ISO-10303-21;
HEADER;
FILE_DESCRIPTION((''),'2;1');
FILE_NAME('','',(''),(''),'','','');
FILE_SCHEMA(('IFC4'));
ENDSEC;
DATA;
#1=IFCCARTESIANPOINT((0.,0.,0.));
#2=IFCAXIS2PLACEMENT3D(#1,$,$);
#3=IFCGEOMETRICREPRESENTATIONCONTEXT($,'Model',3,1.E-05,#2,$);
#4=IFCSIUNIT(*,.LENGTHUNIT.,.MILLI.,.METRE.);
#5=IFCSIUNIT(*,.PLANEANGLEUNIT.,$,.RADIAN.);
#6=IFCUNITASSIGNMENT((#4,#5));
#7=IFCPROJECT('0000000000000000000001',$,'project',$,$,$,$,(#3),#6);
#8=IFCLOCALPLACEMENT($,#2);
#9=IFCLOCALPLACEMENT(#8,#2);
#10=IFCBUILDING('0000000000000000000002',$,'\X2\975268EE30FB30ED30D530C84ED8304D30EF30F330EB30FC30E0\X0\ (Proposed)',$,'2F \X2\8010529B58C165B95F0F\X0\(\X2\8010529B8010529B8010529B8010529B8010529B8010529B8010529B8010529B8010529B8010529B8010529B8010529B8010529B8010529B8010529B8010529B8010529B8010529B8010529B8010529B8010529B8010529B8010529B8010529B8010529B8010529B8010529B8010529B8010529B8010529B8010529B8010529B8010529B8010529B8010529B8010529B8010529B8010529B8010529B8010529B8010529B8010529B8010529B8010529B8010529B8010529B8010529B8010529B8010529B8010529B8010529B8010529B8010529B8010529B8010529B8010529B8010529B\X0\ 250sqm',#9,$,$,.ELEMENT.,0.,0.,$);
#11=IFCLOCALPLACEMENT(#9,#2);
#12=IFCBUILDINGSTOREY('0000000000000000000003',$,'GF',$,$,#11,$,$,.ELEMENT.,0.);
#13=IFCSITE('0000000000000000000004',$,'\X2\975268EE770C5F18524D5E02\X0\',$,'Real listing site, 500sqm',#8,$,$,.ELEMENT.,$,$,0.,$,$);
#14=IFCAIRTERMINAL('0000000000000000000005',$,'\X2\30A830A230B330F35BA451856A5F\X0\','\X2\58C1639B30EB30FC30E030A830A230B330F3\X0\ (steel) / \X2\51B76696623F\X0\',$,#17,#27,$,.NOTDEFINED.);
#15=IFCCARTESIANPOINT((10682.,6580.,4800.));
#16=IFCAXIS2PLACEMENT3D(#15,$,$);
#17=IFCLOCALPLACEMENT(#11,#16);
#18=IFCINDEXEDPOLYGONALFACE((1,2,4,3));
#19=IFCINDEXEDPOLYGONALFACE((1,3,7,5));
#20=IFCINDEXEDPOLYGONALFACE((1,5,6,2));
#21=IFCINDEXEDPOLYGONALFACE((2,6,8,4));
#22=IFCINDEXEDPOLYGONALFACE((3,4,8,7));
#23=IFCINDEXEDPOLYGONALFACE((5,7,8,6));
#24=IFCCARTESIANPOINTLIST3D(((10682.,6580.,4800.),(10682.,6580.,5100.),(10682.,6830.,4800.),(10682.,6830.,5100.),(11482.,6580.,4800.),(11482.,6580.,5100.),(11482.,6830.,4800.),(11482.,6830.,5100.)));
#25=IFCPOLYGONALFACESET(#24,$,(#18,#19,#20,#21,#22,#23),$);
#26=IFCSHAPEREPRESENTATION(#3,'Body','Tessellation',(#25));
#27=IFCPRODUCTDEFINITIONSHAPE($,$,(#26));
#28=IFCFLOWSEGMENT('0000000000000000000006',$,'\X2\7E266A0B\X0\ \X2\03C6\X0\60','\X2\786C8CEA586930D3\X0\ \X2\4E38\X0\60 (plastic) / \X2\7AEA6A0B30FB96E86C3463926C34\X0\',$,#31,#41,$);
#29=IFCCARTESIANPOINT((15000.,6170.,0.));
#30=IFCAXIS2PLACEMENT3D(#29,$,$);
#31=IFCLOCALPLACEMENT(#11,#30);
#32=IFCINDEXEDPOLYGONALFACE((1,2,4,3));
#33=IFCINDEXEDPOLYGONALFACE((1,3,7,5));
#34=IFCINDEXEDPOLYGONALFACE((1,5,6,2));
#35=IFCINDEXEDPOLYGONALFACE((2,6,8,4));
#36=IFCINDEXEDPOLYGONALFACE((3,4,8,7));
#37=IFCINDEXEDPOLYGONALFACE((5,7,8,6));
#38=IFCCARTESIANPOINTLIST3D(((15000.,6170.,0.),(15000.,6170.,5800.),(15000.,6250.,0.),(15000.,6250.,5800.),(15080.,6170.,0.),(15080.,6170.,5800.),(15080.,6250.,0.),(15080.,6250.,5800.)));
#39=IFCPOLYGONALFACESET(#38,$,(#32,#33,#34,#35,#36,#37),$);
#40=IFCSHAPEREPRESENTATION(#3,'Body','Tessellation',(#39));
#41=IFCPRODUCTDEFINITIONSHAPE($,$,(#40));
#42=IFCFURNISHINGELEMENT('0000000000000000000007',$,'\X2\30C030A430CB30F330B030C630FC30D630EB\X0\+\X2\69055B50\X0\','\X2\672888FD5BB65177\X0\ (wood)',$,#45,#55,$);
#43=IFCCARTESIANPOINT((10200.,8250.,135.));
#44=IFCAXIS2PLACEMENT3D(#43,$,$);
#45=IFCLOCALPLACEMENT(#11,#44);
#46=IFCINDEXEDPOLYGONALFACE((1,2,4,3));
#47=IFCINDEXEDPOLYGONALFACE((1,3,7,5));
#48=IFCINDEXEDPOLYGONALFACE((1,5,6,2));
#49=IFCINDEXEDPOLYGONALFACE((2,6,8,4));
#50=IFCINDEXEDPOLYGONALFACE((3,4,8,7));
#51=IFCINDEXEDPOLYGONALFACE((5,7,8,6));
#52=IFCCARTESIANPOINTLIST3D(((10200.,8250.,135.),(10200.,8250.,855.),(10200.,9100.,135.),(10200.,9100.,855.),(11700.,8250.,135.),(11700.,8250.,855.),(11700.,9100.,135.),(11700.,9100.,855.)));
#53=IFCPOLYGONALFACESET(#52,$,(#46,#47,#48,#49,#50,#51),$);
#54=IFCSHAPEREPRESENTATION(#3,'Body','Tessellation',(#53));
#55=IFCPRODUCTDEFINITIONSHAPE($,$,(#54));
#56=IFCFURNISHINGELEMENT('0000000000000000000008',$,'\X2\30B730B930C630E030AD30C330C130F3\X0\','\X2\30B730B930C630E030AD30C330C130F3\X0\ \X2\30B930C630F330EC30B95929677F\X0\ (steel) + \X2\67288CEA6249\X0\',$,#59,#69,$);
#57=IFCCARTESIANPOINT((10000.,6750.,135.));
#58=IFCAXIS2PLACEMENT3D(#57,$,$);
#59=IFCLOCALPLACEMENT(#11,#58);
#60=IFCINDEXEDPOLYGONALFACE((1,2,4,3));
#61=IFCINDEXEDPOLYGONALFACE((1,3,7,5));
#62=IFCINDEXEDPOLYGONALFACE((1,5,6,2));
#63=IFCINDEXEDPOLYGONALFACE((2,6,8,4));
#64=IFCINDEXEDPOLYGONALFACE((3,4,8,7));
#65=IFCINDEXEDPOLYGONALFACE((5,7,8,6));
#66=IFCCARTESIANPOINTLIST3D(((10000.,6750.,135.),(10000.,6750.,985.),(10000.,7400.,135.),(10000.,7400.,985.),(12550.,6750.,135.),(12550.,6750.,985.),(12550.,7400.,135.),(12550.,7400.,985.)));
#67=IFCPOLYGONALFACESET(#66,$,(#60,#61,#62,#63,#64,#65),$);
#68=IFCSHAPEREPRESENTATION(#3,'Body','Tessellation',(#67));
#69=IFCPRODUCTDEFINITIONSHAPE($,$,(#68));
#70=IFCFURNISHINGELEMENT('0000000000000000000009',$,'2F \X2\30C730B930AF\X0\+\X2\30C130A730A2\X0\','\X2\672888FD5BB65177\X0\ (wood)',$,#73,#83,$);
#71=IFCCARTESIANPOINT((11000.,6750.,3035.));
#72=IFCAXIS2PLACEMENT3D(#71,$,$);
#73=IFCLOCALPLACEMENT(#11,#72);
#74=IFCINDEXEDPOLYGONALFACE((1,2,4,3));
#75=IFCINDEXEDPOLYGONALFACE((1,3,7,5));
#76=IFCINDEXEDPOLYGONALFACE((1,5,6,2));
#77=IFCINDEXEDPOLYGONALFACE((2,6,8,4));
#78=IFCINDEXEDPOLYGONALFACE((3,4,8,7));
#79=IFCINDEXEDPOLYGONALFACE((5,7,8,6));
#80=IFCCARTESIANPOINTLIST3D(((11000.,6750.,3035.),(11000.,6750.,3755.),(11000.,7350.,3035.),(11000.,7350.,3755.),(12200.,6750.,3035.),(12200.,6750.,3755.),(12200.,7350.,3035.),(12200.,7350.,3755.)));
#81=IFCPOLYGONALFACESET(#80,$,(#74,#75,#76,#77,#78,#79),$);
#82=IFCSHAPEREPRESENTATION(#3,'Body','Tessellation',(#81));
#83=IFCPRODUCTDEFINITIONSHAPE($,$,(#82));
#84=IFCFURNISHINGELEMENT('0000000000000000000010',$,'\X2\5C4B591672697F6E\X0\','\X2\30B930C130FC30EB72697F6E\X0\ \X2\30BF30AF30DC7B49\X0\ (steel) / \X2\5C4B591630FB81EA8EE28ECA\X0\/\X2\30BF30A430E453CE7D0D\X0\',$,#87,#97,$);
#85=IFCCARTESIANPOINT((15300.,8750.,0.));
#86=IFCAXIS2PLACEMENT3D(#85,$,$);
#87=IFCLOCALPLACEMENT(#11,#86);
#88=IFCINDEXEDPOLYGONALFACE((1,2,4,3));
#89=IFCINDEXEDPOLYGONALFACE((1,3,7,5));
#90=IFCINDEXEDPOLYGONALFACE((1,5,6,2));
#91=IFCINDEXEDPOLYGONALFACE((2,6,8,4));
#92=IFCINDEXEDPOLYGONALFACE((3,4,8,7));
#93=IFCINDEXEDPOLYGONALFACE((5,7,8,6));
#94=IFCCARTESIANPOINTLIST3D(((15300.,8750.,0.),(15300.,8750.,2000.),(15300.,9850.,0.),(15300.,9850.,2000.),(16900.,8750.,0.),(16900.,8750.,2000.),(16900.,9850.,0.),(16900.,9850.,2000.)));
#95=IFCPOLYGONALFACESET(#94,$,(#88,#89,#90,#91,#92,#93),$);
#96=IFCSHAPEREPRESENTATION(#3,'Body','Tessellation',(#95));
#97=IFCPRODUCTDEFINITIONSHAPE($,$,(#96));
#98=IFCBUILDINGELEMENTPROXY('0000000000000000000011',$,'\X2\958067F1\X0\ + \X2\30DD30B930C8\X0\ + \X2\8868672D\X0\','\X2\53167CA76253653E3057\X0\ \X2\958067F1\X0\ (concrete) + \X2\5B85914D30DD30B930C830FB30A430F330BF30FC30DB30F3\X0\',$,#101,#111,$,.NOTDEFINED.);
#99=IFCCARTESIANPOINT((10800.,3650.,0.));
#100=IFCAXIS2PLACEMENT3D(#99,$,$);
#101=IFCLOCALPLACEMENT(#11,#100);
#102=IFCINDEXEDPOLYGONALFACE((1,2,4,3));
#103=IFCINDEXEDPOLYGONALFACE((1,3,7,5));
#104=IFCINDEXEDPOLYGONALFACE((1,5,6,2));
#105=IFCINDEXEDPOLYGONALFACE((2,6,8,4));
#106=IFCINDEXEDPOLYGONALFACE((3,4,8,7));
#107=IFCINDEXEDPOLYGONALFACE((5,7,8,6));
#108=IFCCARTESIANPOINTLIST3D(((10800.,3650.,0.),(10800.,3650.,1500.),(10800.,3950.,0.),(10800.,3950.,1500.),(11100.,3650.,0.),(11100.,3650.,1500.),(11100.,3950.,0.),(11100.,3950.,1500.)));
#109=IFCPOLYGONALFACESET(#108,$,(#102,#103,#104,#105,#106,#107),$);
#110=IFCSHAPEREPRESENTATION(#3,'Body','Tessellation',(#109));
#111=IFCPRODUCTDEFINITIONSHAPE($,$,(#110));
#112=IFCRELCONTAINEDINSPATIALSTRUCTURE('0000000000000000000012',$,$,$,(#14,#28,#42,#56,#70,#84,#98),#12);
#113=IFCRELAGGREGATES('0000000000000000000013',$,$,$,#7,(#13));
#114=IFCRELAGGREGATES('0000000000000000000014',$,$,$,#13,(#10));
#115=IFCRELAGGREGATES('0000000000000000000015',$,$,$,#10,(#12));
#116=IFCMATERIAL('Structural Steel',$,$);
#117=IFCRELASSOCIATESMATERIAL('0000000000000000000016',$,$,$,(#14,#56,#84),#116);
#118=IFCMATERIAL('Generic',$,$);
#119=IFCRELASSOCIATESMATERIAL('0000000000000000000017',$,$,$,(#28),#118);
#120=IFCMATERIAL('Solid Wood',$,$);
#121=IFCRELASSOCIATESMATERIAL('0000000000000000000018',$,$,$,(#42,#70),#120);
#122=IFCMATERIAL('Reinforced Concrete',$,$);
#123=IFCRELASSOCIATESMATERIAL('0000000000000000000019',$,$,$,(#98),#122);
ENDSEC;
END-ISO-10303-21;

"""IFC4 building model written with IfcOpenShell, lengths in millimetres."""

from ifc_helpers import new_model, si_unit, frame, frame_2d, origin, place, context, project, spatial, rectangle, extrude, material, element, save


model = new_model("IFC4")

# Units and contexts
model_context = context("Model", 3, precision=1e-05, world=origin())
ifc_project = project(units=[si_unit("LENGTHUNIT", "METRE", prefix="MILLI"), si_unit("PLANEANGLEUNIT", "RADIAN")], contexts=[model_context])

# Site, building, storey
site_placement = place(None, origin())
site = spatial("IfcSite", under=ifc_project, at=site_placement, Name="青森県弘前市", ObjectType="Real listing site, 500sqm", CompositionType="ELEMENT", RefElevation=0.0)
building_placement = place(site_placement, origin())
building = spatial("IfcBuilding", under=site, at=building_placement, Name="青森・ロフト付きワンルーム (Proposed)", ObjectType="2F 耐力壁方式(耐力耐力耐力耐力耐力耐力耐力耐力耐力耐力耐力耐力耐力耐力耐力耐力耐力耐力耐力耐力耐力耐力耐力耐力耐力耐力耐力耐力耐力耐力耐力耐力耐力耐力耐力耐力耐力耐力耐力耐力耐力耐力耐力耐力耐力耐力耐力耐力耐力耐力耐力耐力耐力耐力耐力耐力耐力 250sqm", CompositionType="ELEMENT", ElevationOfRefHeight=0.0, ElevationOfTerrain=0.0)
storey_placement = place(building_placement, origin())
storey = spatial("IfcBuildingStorey", under=building, at=storey_placement, Name="GF", CompositionType="ELEMENT", Elevation=0.0)

# Shared definitions
ifc_material_1 = material(Name="Solid Wood")

# Shared definitions
ifc_material_2 = material(Name="Reinforced Concrete")

# Shared definitions
ifc_material_3 = material(Name="Structural Steel")

# Shared definitions
ifc_material_4 = material(Name="Generic")

# Air terminal
air_terminal_placement = place(storey_placement, frame((10682.0, 6580.0, 4800.0)))
element("IfcAirTerminal", 1, at=air_terminal_placement, inside=storey, material=ifc_material_3, Name="エアコン室内機", Description="壁掛ルームエアコン (steel) / 冷暖房", PredefinedType="NOTDEFINED", context=model_context, shape_type="SweptSolid", body=[
    extrude(rectangle(XDim=800.0, YDim=250.0, at=frame_2d((400.0, 125.0))), frame((10682.0, 6580.0, 4800.0)), (0.0, 0.0, 1.0), 300.0),
])

# Flow segment
flow_segment_placement = place(storey_placement, frame((15000.0, 6170.0, 0.0)))
element("IfcFlowSegment", 2, at=flow_segment_placement, inside=storey, material=ifc_material_4, Name="縦樋 φ60", Description="硬質塩ビ 丸60 (plastic) / 竪樋・雨水排水", context=model_context, shape_type="SweptSolid", body=[
    extrude(rectangle(XDim=80.0, YDim=80.0, at=frame_2d((40.0, 40.0))), frame((15000.0, 6170.0, 0.0)), (0.0, 0.0, 1.0), 5800.0),
])

# Furnishing elements
furnishing_1_placement = place(storey_placement, frame((10200.0, 8250.0, 135.0)))
element("IfcFurnishingElement", 3, at=furnishing_1_placement, inside=storey, material=ifc_material_1, Name="ダイニングテーブル+椅子", Description="木製家具 (wood)", context=model_context, shape_type="SweptSolid", body=[
    extrude(rectangle(XDim=1500.0, YDim=850.0, at=frame_2d((750.0, 425.0))), frame((10200.0, 8250.0, 135.0)), (0.0, 0.0, 1.0), 720.0),
])
furnishing_2_placement = place(storey_placement, frame((10000.0, 6750.0, 135.0)))
element("IfcFurnishingElement", 4, at=furnishing_2_placement, inside=storey, material=ifc_material_3, Name="システムキッチン", Description="システムキッチン ステンレス天板 (steel) + 木質扉", context=model_context, shape_type="SweptSolid", body=[
    extrude(rectangle(XDim=2550.0, YDim=650.0, at=frame_2d((1275.0, 325.0))), frame((10000.0, 6750.0, 135.0)), (0.0, 0.0, 1.0), 850.0),
])
furnishing_3_placement = place(storey_placement, frame((11000.0, 6750.0, 3035.0)))
element("IfcFurnishingElement", 5, at=furnishing_3_placement, inside=storey, material=ifc_material_1, Name="2F デスク+チェア", Description="木製家具 (wood)", context=model_context, shape_type="SweptSolid", body=[
    extrude(rectangle(XDim=1200.0, YDim=600.0, at=frame_2d((600.0, 300.0))), frame((11000.0, 6750.0, 3035.0)), (0.0, 0.0, 1.0), 720.0),
])
furnishing_4_placement = place(storey_placement, frame((15300.0, 8750.0, 0.0)))
element("IfcFurnishingElement", 6, at=furnishing_4_placement, inside=storey, material=ifc_material_3, Name="屋外物置", Description="スチール物置 タクボ等 (steel) / 屋外・自転車/タイヤ収納", context=model_context, shape_type="SweptSolid", body=[
    extrude(rectangle(XDim=1600.0, YDim=1100.0, at=frame_2d((800.0, 550.0))), frame((15300.0, 8750.0, 0.0)), (0.0, 0.0, 1.0), 2000.0),
])

# Building element proxy
proxy_placement = place(storey_placement, frame((10800.0, 3650.0, 0.0)))
element("IfcBuildingElementProxy", 7, at=proxy_placement, inside=storey, material=ifc_material_2, Name="門柱 + ポスト + 表札", Description="化粧打放し 門柱 (concrete) + 宅配ポスト・インターホン", PredefinedType="NOTDEFINED", context=model_context, shape_type="SweptSolid", body=[
    extrude(rectangle(XDim=300.0, YDim=300.0, at=frame_2d((150.0, 150.0))), frame((10800.0, 3650.0, 0.0)), (0.0, 0.0, 1.0), 1500.0),
])

save(model, "model.ifc")
